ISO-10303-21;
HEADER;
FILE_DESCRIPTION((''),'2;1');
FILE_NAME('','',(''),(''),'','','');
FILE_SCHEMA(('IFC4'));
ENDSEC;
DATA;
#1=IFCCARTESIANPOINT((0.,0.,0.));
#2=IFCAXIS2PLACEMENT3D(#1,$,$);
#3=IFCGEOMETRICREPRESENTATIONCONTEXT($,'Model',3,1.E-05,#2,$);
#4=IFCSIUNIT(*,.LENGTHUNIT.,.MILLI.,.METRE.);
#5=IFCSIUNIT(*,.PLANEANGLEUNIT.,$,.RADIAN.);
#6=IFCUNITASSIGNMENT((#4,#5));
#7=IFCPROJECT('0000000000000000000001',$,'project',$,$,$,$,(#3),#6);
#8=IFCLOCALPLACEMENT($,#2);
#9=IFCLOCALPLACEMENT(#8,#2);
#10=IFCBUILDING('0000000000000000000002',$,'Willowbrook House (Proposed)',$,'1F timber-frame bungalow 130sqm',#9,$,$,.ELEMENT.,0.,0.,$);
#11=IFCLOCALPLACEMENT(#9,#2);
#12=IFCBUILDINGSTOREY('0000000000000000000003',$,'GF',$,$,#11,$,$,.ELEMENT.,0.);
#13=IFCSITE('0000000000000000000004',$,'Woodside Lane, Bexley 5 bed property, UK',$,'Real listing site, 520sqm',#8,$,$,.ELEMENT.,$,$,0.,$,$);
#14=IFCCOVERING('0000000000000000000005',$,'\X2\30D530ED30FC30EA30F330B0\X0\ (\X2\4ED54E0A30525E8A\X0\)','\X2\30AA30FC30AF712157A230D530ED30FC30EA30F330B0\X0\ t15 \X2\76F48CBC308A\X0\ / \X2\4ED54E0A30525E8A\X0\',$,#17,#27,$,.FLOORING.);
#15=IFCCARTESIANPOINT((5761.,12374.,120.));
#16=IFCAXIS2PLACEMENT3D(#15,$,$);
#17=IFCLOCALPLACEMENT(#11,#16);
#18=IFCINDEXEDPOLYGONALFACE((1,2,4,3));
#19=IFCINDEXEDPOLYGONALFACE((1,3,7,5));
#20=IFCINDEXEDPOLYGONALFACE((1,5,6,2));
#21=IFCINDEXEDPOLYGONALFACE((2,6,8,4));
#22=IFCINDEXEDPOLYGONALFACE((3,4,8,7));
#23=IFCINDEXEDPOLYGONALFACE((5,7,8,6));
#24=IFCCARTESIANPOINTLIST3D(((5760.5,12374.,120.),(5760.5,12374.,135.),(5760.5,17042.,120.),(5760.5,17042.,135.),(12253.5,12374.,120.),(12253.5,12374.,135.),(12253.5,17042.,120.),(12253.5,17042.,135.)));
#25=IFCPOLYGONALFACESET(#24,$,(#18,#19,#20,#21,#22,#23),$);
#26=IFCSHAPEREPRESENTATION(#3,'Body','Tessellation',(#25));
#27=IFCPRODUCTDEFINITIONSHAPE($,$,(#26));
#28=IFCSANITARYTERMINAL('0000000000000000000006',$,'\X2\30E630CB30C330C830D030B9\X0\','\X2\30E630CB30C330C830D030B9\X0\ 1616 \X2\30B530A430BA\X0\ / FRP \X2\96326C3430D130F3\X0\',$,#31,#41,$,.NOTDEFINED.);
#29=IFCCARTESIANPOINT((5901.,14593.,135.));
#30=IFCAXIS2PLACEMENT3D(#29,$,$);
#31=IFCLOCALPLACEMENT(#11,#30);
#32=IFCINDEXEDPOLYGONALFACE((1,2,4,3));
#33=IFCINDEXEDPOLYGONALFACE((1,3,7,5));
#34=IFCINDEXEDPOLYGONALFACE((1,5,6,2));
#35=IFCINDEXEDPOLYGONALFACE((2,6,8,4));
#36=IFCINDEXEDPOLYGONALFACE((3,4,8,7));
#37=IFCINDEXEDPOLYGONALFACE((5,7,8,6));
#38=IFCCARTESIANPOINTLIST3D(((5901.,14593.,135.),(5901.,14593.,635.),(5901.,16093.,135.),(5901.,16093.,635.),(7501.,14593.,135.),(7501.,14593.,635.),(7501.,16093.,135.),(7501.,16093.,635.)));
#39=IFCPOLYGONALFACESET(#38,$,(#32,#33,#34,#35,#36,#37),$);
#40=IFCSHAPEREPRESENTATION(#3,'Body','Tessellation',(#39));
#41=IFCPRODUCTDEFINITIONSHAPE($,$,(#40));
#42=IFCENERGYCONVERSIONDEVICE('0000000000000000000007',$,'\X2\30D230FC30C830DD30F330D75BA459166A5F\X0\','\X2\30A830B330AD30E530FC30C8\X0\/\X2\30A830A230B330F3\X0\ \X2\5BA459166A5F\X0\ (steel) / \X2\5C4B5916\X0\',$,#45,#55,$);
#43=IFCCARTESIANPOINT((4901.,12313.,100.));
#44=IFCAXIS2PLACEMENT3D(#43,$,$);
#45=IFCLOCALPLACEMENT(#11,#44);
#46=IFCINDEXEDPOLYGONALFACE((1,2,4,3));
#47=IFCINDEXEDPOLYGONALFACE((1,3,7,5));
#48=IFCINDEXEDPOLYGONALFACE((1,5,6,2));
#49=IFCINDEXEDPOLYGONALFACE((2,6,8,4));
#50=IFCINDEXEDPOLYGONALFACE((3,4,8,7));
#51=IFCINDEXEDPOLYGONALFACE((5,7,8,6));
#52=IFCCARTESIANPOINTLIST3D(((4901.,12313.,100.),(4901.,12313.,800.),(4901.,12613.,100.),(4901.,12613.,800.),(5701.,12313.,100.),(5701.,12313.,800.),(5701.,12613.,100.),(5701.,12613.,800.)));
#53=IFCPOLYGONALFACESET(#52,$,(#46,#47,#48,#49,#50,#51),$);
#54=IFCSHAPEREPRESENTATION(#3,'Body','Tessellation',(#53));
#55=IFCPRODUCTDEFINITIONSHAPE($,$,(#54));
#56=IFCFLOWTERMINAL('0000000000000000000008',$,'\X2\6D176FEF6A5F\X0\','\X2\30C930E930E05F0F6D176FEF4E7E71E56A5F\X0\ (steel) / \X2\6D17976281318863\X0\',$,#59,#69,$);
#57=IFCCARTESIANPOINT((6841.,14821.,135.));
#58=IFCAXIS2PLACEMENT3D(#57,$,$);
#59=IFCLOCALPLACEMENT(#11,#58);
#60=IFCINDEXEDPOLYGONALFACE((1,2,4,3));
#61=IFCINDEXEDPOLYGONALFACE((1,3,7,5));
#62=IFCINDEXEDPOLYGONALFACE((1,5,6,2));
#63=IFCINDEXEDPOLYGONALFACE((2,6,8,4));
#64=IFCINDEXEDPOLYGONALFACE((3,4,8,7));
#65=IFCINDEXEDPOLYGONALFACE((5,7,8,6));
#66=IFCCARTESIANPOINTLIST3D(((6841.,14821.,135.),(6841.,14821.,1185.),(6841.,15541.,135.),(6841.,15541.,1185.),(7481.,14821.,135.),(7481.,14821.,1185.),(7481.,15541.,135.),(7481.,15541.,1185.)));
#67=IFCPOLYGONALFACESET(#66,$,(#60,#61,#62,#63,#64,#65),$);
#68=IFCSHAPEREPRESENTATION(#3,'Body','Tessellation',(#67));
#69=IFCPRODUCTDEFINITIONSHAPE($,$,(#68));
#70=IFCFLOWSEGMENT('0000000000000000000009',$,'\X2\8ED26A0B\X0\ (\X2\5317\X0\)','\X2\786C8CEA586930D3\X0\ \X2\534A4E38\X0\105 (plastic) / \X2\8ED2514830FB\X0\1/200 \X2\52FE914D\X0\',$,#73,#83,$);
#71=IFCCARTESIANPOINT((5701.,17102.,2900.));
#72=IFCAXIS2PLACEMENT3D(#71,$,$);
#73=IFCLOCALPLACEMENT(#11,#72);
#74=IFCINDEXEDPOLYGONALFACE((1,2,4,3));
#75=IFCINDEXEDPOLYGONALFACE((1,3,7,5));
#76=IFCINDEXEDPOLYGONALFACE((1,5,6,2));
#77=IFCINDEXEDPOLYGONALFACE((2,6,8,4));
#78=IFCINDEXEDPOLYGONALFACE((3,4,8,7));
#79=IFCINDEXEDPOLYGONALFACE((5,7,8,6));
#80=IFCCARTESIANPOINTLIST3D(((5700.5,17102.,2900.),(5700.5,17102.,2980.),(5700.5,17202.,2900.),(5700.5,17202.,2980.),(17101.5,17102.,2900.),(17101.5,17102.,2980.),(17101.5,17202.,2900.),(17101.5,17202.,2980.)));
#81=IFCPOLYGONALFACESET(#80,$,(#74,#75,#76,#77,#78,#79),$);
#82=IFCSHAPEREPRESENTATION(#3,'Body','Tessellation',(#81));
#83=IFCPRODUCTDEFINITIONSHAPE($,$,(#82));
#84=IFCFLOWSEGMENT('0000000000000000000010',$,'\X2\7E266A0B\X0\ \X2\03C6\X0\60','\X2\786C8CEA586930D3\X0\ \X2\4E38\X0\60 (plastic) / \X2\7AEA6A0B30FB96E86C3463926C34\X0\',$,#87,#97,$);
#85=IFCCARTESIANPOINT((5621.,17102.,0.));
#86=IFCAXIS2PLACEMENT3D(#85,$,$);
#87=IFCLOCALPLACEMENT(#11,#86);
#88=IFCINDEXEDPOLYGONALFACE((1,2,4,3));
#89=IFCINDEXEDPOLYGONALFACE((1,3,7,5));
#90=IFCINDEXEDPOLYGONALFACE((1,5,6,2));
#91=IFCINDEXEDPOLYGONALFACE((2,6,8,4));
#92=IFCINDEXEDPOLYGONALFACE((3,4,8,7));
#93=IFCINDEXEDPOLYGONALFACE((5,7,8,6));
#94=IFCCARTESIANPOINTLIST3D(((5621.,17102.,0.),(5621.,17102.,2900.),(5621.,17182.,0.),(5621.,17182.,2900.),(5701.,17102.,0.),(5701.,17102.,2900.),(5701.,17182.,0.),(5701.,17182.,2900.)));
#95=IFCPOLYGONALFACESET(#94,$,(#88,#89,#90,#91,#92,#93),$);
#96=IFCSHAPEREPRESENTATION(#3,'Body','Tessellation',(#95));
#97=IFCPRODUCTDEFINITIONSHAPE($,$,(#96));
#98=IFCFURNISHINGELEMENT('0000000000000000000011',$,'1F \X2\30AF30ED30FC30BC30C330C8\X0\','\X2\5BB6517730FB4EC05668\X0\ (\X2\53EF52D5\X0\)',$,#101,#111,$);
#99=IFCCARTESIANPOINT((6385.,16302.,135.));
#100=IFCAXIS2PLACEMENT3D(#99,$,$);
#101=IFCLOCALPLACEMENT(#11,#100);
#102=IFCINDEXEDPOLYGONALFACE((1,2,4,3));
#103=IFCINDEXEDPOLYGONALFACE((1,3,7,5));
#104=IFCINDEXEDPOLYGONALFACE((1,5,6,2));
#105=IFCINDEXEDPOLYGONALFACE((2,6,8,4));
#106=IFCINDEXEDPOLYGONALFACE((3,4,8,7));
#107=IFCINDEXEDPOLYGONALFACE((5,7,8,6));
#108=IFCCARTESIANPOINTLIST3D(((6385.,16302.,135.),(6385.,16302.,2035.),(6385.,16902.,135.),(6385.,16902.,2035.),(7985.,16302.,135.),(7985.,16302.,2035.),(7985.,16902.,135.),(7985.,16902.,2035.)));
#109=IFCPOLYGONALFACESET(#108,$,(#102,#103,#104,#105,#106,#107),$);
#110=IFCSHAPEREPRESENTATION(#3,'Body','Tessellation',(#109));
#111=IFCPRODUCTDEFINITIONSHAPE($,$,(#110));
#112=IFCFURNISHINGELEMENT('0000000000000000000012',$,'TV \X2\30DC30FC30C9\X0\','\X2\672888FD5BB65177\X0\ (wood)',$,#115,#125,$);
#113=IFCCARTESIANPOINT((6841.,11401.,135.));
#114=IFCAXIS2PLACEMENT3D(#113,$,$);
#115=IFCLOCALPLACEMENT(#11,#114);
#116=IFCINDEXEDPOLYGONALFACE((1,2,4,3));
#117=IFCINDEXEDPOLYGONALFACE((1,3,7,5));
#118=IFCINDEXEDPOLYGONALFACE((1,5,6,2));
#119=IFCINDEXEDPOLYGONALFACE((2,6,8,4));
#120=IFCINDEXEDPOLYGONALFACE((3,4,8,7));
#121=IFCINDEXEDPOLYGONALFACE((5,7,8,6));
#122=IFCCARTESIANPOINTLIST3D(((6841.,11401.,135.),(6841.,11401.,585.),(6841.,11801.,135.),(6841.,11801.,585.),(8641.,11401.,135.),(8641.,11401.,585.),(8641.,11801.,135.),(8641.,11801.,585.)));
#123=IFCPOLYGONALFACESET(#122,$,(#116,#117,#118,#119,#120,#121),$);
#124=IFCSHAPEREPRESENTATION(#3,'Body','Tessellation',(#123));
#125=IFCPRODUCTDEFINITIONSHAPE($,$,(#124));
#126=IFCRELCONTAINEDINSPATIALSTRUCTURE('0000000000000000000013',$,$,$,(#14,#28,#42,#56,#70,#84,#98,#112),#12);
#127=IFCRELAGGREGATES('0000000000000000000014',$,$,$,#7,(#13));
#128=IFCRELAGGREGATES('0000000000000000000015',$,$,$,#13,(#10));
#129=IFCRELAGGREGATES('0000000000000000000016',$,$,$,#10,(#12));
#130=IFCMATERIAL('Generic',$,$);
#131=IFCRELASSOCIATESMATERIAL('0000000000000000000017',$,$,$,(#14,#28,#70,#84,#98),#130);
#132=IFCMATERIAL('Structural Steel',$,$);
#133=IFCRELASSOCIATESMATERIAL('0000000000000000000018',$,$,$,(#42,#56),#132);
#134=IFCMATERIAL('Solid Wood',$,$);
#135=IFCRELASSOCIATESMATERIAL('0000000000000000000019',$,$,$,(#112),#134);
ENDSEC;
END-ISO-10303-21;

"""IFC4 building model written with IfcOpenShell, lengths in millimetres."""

from ifc_helpers import new_model, si_unit, frame, frame_2d, origin, place, context, project, spatial, rectangle, extrude, material, element, save


model = new_model("IFC4")

# Units and contexts
model_context = context("Model", 3, precision=1e-05, world=origin())
ifc_project = project(units=[si_unit("LENGTHUNIT", "METRE", prefix="MILLI"), si_unit("PLANEANGLEUNIT", "RADIAN")], contexts=[model_context])

# Site, building, storey
site_placement = place(None, origin())
site = spatial("IfcSite", under=ifc_project, at=site_placement, Name="Woodside Lane, Bexley 5 bed property, UK", ObjectType="Real listing site, 520sqm", CompositionType="ELEMENT", RefElevation=0.0)
building_placement = place(site_placement, origin())
building = spatial("IfcBuilding", under=site, at=building_placement, Name="Willowbrook House (Proposed)", ObjectType="1F timber-frame bungalow 130sqm", CompositionType="ELEMENT", ElevationOfRefHeight=0.0, ElevationOfTerrain=0.0)
storey_placement = place(building_placement, origin())
storey = spatial("IfcBuildingStorey", under=building, at=storey_placement, Name="GF", CompositionType="ELEMENT", Elevation=0.0)

# Shared definitions
ifc_material_1 = material(Name="Solid Wood")

# Shared definitions
ifc_material_2 = material(Name="Structural Steel")

# Covering
ifc_material_3 = material(Name="Generic")
covering_placement = place(storey_placement, frame((5761.0, 12374.0, 120.0)))
element("IfcCovering", 1, at=covering_placement, inside=storey, material=ifc_material_3, Name="フローリング (仕上げ床)", Description="オーク無垢フローリング t15 直貼り / 仕上げ床", PredefinedType="FLOORING", context=model_context, shape_type="SweptSolid", body=[
    extrude(rectangle(XDim=6493.0, YDim=4668.0, at=frame_2d((3246.0, 2334.0))), frame((5761.0, 12374.0, 120.0)), (0.0, 0.0, 1.0), 15.0),
])

# Sanitary terminal
sanitary_terminal_placement = place(storey_placement, frame((5901.0, 14593.0, 135.0)))
element("IfcSanitaryTerminal", 2, at=sanitary_terminal_placement, inside=storey, material=ifc_material_3, Name="ユニットバス", Description="ユニットバス 1616 サイズ / FRP 防水パン", PredefinedType="NOTDEFINED", context=model_context, shape_type="SweptSolid", body=[
    extrude(rectangle(XDim=1600.0, YDim=1500.0, at=frame_2d((800.0, 750.0))), frame((5901.0, 14593.0, 135.0)), (0.0, 0.0, 1.0), 500.0),
])

# Energy conversion device
energy_conversion_device_placement = place(storey_placement, frame((4901.0, 12313.0, 100.0)))
element("IfcEnergyConversionDevice", 3, at=energy_conversion_device_placement, inside=storey, material=ifc_material_2, Name="ヒートポンプ室外機", Description="エコキュート/エアコン 室外機 (steel) / 屋外", context=model_context, shape_type="SweptSolid", body=[
    extrude(rectangle(XDim=800.0, YDim=300.0, at=frame_2d((400.0, 150.0))), frame((4901.0, 12313.0, 100.0)), (0.0, 0.0, 1.0), 700.0),
])

# Flow terminal
flow_terminal_placement = place(storey_placement, frame((6841.0, 14821.0, 135.0)))
element("IfcFlowTerminal", 4, at=flow_terminal_placement, inside=storey, material=ifc_material_2, Name="洗濯機", Description="ドラム式洗濯乾燥機 (steel) / 洗面脱衣", context=model_context, shape_type="SweptSolid", body=[
    extrude(rectangle(XDim=640.0, YDim=720.0, at=frame_2d((320.0, 360.0))), frame((6841.0, 14821.0, 135.0)), (0.0, 0.0, 1.0), 1050.0),
])

# Flow segments
flow_segment_1_placement = place(storey_placement, frame((5701.0, 17102.0, 2900.0)))
element("IfcFlowSegment", 5, at=flow_segment_1_placement, inside=storey, material=ifc_material_3, Name="軒樋 (北)", Description="硬質塩ビ 半丸105 (plastic) / 軒先・1/200 勾配", context=model_context, shape_type="SweptSolid", body=[
    extrude(rectangle(XDim=11401.0, YDim=100.0, at=frame_2d((5700.0, 50.0))), frame((5701.0, 17102.0, 2900.0)), (0.0, 0.0, 1.0), 80.0),
])
flow_segment_2_placement = place(storey_placement, frame((5621.0, 17102.0, 0.0)))
element("IfcFlowSegment", 6, at=flow_segment_2_placement, inside=storey, material=ifc_material_3, Name="縦樋 φ60", Description="硬質塩ビ 丸60 (plastic) / 竪樋・雨水排水", context=model_context, shape_type="SweptSolid", body=[
    extrude(rectangle(XDim=80.0, YDim=80.0, at=frame_2d((40.0, 40.0))), frame((5621.0, 17102.0, 0.0)), (0.0, 0.0, 1.0), 2900.0),
])

# Furnishing elements
furnishing_1_placement = place(storey_placement, frame((6385.0, 16302.0, 135.0)))
element("IfcFurnishingElement", 7, at=furnishing_1_placement, inside=storey, material=ifc_material_3, Name="1F クローゼット", Description="家具・什器 (可動)", context=model_context, shape_type="SweptSolid", body=[
    extrude(rectangle(XDim=1600.0, YDim=600.0, at=frame_2d((800.0, 300.0))), frame((6385.0, 16302.0, 135.0)), (0.0, 0.0, 1.0), 1900.0),
])
furnishing_2_placement = place(storey_placement, frame((6841.0, 11401.0, 135.0)))
element("IfcFurnishingElement", 8, at=furnishing_2_placement, inside=storey, material=ifc_material_1, Name="TV ボード", Description="木製家具 (wood)", context=model_context, shape_type="SweptSolid", body=[
    extrude(rectangle(XDim=1800.0, YDim=400.0, at=frame_2d((900.0, 200.0))), frame((6841.0, 11401.0, 135.0)), (0.0, 0.0, 1.0), 450.0),
])

save(model, "model.ifc")
